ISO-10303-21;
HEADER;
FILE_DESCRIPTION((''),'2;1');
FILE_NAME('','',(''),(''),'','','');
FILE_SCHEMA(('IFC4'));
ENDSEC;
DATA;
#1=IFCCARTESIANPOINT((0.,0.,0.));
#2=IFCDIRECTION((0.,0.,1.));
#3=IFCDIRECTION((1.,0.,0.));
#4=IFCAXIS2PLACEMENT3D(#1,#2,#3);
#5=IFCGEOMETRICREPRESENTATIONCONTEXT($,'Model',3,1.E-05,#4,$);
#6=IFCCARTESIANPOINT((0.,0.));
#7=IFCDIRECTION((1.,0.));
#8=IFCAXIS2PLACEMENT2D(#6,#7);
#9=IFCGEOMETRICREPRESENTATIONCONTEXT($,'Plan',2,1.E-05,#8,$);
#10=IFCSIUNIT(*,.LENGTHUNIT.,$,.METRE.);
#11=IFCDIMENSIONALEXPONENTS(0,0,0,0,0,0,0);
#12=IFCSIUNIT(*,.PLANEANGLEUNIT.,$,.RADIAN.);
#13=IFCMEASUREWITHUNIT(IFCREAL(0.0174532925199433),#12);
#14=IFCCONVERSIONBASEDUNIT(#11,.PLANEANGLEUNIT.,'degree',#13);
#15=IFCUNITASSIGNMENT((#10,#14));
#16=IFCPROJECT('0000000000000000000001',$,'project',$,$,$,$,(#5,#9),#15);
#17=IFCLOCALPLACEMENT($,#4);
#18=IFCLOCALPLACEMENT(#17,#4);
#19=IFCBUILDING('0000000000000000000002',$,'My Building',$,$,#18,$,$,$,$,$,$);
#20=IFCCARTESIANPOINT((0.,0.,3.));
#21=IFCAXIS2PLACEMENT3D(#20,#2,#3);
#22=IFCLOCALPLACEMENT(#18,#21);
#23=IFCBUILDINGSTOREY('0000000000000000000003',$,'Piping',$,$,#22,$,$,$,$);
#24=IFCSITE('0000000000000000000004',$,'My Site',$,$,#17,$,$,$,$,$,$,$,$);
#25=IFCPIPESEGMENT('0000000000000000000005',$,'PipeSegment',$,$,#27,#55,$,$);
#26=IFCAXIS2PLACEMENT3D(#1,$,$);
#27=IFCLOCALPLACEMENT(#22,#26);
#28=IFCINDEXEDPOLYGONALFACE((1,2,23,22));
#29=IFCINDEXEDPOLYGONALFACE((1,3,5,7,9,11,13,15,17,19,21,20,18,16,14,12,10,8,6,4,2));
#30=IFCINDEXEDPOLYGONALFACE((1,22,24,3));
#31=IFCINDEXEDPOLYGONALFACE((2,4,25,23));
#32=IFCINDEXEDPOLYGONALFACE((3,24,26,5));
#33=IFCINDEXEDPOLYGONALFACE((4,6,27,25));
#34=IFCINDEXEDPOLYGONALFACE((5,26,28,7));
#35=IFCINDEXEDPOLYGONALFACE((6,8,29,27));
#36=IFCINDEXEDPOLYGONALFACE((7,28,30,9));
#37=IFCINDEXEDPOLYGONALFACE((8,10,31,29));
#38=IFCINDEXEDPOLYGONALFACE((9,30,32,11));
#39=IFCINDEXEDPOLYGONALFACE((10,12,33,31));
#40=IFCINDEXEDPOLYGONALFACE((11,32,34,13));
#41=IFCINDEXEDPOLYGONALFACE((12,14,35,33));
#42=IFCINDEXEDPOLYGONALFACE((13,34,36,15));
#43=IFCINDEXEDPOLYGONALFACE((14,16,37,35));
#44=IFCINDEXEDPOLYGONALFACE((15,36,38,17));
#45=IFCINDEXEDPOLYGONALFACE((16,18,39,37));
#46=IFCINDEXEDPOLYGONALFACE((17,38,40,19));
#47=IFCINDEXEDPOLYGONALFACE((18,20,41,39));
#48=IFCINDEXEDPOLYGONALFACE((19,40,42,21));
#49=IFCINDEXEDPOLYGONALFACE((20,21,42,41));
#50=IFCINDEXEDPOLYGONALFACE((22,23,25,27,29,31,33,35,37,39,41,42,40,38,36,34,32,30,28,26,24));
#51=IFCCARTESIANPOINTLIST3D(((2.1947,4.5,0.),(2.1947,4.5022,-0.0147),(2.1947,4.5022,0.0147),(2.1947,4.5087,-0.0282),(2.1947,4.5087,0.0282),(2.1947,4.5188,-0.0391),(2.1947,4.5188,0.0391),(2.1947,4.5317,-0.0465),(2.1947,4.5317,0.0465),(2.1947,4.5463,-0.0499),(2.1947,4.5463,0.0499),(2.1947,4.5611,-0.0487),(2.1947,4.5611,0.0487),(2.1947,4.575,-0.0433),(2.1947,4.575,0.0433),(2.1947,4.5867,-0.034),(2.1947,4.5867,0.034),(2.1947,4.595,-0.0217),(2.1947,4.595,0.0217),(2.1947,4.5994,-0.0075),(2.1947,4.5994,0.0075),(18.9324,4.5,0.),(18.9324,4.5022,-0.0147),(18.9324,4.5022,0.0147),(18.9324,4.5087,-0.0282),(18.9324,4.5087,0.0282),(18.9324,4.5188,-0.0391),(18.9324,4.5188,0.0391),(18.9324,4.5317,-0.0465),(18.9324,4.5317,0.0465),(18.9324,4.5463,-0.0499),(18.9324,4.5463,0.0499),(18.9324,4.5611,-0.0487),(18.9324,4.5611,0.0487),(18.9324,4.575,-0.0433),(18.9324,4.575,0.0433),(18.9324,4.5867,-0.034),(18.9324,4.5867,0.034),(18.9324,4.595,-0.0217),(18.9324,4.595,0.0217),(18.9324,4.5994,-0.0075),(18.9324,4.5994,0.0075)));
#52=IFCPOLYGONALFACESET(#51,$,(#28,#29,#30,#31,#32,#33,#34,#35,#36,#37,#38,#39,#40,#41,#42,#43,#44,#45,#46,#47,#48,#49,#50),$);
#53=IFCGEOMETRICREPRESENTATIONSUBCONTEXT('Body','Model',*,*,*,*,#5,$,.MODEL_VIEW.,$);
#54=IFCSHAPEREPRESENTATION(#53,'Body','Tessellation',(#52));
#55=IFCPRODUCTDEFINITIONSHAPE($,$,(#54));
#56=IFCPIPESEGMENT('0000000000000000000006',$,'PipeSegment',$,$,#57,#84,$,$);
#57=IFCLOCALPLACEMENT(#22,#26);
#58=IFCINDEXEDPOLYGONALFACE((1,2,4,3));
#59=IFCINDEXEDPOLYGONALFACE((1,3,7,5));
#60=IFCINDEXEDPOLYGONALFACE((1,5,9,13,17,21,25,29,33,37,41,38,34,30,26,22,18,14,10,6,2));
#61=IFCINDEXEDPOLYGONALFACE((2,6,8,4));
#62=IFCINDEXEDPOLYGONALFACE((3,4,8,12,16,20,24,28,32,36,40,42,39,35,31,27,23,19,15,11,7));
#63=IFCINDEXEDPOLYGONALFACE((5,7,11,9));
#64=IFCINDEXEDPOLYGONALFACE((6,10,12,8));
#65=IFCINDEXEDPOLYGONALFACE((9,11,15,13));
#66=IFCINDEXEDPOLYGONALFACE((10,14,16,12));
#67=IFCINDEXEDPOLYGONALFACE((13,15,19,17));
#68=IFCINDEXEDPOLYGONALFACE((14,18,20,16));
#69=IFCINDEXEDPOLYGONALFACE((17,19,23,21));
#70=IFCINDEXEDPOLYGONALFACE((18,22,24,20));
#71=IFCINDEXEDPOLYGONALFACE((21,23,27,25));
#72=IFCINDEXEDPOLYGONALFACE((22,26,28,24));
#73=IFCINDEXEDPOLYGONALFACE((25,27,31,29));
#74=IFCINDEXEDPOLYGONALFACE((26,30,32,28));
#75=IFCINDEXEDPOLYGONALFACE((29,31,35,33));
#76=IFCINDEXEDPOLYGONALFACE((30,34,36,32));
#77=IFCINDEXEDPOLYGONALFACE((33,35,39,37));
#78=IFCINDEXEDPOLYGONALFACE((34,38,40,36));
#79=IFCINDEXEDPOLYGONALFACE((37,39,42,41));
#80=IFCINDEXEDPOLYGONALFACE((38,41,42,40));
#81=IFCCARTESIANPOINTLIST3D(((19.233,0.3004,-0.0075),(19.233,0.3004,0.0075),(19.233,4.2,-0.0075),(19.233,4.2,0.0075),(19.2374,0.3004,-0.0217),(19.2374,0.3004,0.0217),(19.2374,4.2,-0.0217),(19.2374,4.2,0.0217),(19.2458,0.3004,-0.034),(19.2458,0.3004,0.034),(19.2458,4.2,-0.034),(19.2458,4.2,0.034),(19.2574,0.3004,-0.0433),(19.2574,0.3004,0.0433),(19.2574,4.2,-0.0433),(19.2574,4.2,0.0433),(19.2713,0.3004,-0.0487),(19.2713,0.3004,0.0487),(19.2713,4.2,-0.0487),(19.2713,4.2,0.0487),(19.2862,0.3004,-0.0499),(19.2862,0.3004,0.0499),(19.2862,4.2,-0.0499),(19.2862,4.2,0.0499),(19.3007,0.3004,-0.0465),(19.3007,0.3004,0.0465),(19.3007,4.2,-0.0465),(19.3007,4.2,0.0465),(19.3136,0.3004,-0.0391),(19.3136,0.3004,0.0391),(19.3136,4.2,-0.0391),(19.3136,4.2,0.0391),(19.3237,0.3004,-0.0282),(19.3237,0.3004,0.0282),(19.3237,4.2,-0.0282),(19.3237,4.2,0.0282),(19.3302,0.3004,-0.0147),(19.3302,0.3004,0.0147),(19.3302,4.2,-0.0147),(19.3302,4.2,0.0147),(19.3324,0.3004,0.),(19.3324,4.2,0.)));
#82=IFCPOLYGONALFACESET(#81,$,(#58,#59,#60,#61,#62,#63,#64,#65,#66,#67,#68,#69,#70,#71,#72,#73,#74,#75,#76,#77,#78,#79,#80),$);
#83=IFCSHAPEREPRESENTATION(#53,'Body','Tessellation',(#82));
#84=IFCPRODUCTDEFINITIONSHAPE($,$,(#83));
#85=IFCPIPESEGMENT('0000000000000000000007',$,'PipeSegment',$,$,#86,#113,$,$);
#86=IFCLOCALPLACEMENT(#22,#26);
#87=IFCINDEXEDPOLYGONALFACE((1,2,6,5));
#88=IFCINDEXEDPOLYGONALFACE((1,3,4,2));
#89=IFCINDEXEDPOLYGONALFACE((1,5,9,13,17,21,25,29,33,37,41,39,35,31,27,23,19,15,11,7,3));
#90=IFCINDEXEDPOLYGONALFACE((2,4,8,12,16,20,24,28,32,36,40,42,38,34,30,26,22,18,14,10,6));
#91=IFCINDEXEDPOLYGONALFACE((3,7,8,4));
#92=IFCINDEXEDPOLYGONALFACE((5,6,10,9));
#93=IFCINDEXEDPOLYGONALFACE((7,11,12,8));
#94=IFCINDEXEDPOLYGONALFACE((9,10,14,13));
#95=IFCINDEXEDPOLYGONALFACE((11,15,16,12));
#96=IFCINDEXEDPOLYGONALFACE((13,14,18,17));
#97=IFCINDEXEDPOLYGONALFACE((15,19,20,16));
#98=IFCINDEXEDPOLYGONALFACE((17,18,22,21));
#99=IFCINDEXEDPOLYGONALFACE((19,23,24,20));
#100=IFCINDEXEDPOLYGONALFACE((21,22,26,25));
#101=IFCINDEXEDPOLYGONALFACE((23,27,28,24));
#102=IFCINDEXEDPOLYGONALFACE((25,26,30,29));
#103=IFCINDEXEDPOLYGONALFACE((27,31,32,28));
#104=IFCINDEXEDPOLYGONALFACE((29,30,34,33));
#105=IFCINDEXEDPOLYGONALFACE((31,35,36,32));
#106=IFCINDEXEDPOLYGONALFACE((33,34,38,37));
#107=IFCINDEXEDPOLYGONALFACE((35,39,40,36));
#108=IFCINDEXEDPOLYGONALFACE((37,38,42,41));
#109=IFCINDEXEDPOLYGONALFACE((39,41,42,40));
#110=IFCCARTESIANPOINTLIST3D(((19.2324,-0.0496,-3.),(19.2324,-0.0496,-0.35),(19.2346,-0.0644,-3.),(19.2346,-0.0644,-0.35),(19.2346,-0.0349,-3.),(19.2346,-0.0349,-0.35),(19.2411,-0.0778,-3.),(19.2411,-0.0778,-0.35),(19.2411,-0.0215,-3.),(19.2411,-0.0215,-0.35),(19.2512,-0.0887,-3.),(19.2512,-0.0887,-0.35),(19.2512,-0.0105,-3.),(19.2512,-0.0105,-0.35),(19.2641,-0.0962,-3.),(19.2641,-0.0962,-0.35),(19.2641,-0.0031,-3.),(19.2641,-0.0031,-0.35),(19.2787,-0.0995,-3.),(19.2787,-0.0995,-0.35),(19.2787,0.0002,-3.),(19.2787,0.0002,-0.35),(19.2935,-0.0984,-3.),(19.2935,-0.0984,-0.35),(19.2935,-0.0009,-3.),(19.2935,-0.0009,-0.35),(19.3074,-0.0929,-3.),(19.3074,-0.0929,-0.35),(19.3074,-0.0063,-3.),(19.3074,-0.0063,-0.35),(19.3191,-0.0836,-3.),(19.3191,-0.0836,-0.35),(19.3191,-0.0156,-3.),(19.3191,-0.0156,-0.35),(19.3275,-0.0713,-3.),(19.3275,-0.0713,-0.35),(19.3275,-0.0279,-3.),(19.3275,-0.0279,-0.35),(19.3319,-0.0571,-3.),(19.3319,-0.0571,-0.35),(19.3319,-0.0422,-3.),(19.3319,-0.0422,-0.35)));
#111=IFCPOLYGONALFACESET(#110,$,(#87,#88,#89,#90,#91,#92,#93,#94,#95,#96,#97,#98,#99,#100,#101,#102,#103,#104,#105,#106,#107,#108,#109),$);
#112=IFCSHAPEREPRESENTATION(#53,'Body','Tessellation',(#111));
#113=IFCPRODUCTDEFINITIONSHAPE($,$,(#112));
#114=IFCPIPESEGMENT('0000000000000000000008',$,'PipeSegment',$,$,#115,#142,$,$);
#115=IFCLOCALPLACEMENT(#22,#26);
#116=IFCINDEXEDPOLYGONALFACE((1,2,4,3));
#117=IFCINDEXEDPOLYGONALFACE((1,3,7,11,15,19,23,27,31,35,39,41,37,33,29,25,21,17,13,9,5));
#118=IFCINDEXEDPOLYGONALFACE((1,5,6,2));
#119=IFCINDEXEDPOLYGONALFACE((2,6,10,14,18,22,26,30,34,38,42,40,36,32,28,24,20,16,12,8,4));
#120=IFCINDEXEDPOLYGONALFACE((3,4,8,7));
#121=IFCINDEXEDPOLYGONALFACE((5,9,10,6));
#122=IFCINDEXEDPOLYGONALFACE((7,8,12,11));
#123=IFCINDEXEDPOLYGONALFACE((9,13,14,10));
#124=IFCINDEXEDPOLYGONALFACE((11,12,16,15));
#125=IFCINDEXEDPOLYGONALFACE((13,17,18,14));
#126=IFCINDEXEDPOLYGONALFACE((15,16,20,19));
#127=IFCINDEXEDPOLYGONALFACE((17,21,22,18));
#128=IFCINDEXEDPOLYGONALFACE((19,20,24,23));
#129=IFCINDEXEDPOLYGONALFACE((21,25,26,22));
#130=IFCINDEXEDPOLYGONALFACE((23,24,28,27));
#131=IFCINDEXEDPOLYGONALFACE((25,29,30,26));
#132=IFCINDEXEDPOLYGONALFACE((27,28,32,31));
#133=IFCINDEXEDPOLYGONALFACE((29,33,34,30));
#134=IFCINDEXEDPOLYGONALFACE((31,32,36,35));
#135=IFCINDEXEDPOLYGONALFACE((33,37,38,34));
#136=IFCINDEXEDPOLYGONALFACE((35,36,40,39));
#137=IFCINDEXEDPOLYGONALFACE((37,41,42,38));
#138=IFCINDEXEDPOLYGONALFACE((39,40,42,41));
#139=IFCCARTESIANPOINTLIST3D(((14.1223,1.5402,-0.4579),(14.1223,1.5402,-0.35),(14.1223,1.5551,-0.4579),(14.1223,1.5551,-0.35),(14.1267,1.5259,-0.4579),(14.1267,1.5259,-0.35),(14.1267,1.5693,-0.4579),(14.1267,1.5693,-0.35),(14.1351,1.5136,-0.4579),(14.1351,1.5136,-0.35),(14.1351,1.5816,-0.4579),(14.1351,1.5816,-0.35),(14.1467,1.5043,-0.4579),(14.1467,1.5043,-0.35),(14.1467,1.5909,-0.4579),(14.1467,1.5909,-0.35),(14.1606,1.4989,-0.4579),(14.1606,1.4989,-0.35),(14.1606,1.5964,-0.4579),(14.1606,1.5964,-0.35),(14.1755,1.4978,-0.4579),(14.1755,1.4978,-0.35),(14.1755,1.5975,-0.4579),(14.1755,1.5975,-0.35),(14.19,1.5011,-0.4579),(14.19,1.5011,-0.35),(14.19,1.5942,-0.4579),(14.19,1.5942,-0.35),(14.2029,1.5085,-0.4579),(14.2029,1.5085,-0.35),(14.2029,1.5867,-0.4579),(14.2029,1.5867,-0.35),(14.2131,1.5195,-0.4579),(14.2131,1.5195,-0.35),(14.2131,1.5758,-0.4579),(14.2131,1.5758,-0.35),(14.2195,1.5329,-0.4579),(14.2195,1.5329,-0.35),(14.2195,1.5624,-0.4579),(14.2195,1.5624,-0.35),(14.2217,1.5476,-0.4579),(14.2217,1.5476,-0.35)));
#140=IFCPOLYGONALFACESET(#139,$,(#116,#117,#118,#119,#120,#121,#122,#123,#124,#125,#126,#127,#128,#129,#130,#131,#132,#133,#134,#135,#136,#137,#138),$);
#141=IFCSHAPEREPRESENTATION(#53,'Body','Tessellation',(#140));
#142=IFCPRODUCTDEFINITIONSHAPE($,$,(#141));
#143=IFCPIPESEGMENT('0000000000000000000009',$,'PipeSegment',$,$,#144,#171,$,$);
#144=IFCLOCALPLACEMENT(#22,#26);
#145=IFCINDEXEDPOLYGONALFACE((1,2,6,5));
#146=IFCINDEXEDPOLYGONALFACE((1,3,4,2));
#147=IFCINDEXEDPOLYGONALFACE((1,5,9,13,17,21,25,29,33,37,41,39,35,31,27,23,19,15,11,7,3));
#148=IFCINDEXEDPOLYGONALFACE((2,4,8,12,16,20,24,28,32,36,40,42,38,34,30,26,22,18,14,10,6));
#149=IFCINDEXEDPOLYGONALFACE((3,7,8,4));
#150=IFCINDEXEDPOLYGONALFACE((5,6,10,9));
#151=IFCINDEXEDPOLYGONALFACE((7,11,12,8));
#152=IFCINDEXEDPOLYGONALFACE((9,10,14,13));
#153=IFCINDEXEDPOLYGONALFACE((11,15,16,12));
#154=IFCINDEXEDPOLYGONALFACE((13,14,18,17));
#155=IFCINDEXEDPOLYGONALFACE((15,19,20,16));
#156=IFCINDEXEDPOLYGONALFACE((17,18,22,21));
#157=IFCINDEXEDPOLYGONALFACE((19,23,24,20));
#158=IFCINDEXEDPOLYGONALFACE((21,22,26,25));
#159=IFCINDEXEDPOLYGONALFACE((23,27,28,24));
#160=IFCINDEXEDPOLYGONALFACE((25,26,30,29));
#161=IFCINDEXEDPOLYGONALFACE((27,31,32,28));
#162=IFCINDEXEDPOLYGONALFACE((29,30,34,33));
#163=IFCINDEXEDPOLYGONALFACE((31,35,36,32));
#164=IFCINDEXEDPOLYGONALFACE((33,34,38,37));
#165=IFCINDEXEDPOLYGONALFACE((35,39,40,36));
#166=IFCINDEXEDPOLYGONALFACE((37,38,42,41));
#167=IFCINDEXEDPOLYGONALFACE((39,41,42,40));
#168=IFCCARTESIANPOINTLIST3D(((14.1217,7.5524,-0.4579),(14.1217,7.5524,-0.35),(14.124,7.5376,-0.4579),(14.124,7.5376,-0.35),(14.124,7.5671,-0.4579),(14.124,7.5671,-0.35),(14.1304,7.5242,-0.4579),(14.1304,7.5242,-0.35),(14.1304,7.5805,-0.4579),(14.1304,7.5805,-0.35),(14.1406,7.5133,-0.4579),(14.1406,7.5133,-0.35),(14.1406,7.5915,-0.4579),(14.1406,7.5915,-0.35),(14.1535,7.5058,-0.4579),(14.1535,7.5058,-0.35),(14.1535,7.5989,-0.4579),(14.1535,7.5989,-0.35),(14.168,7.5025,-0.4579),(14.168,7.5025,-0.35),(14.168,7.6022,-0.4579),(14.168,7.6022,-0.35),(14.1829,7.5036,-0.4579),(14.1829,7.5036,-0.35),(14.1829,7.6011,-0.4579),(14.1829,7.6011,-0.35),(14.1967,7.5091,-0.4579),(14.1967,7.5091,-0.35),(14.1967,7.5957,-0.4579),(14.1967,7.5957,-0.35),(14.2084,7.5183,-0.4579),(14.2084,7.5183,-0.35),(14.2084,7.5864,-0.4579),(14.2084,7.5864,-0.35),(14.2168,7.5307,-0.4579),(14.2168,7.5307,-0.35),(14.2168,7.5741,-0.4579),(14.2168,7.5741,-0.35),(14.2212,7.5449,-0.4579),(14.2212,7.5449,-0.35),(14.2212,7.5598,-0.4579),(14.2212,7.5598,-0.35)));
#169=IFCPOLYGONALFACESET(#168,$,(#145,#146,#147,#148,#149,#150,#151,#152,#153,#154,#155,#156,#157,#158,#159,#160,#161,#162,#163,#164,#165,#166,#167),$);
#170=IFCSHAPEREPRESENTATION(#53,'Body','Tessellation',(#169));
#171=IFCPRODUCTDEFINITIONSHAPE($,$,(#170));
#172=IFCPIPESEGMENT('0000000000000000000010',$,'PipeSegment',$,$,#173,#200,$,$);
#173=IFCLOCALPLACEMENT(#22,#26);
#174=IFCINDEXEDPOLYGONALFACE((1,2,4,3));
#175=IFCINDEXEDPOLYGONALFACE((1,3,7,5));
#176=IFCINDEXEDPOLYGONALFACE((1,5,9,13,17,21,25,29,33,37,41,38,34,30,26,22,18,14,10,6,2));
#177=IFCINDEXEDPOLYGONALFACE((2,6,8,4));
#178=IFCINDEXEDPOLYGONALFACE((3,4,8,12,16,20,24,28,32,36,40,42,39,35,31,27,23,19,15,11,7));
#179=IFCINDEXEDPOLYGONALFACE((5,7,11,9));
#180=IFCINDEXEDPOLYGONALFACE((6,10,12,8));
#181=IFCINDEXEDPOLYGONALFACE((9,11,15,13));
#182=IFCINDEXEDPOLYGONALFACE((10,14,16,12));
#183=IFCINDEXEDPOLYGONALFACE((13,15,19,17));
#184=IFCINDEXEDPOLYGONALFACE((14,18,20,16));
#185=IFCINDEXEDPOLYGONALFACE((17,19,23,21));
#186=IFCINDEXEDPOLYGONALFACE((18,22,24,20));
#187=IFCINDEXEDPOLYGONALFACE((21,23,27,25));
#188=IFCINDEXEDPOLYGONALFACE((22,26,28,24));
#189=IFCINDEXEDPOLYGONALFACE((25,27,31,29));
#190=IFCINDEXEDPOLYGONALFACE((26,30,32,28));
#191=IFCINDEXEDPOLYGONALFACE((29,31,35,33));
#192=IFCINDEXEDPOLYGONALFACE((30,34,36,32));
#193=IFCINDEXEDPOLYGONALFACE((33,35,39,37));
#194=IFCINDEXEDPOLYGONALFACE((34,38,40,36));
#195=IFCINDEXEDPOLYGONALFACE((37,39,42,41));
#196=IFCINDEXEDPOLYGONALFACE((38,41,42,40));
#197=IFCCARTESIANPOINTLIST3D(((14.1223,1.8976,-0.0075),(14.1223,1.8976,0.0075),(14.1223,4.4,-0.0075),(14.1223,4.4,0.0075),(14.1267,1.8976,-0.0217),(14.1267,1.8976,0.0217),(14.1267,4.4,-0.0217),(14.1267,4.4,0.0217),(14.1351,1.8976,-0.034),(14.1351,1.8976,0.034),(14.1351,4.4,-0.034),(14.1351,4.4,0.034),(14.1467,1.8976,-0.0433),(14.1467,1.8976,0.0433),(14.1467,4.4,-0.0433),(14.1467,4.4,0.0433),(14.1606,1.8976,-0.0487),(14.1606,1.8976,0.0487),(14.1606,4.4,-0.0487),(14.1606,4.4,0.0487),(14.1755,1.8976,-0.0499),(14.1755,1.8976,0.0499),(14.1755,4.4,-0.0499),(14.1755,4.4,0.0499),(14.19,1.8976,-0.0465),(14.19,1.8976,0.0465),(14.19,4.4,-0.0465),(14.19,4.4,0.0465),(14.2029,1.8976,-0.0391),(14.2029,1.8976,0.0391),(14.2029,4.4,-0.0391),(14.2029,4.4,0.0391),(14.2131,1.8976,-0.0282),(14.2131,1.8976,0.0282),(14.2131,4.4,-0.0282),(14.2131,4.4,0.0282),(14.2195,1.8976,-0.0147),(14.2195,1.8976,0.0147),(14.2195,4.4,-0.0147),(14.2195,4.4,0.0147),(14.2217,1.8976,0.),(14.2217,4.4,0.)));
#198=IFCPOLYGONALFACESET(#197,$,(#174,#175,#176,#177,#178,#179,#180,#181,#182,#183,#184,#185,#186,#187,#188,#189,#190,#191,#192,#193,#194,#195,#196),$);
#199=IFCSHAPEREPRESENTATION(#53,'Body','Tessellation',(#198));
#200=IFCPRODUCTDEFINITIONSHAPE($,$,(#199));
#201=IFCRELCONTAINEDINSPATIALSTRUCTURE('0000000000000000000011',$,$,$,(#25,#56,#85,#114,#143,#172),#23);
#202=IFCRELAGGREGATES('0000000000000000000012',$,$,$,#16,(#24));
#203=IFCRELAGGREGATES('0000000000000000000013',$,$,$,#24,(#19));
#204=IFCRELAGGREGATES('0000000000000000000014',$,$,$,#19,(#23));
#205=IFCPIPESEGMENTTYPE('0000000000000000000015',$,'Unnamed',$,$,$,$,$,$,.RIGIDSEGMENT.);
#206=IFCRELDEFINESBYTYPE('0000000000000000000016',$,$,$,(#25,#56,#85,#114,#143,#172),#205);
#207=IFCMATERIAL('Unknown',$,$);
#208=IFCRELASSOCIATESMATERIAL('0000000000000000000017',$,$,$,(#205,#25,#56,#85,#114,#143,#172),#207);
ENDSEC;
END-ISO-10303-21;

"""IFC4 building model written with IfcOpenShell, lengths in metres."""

from ifc_helpers import new_model, entity, si_unit, converted_unit, frame, origin_with_axes, origin_2d_with_axis, place, context, subcontext, project, spatial, circle, extrude, material, material_profile, profile_set, profile_usage, type_object, element, save


model = new_model("IFC4")

# Units and contexts
model_context = context("Model", 3, precision=1e-05, world=origin_with_axes())
plan_context = context("Plan", 2, precision=1e-05, world=origin_2d_with_axis())
body_context = subcontext(model_context, "Body", "Model", "MODEL_VIEW")
ifc_project = project(units=[si_unit("LENGTHUNIT", "METRE"), converted_unit("PLANEANGLEUNIT", "degree", entity("IfcReal", 0.0174532925199433), si_unit("PLANEANGLEUNIT", "RADIAN"), dimensions=[0, 0, 0, 0, 0, 0, 0])], contexts=[model_context, plan_context])

# Site, building, storey
site_placement = place(None, origin_with_axes())
site = spatial("IfcSite", under=ifc_project, at=site_placement, Name="My Site")
building_placement = place(site_placement, origin_with_axes())
building = spatial("IfcBuilding", under=site, at=building_placement, Name="My Building")
storey_placement = place(building_placement, frame((0.0, 0.0, 3.0), z_axis=(0.0, 0.0, 1.0), x_axis=(1.0, 0.0, 0.0)))
storey = spatial("IfcBuildingStorey", under=building, at=storey_placement, Name="Piping")

# Pipe segments
ifc_material = material(Name="Unknown")
ifc_material_profile_1 = material_profile(ifc_material, circle(Radius=0.05))
ifc_profile_set_1 = profile_set([ifc_material_profile_1])
ifc_profile_usage_1 = profile_usage(ifc_profile_set_1, cardinal=5)
pipe_segment_type = type_object("IfcPipeSegmentType", Name="Unnamed", PredefinedType="RIGIDSEGMENT", material=ifc_profile_set_1)
pipe_segment_1_placement = place(storey_placement, frame((18.9324, 4.55, 0.0), z_axis=(-1.0, 0.0, 0.0), x_axis=(0.0, -1.0, 0.0)))
element("IfcPipeSegment", 1, at=pipe_segment_1_placement, inside=storey, type_object=pipe_segment_type, material=ifc_profile_usage_1, Name="PipeSegment", context=body_context, shape_type="SweptSolid", body=[
    extrude(circle(Radius=0.05), origin_with_axes(), (0.0, 0.0, 1.0), 16.7377),
])
ifc_profile_usage_2 = profile_usage(ifc_profile_set_1, cardinal=5)
pipe_segment_2_placement = place(storey_placement, frame((19.2824, 4.2, 0.0), z_axis=(0.0, -1.0, 0.0), x_axis=(1.0, 0.0, 0.0)))
element("IfcPipeSegment", 2, at=pipe_segment_2_placement, inside=storey, type_object=pipe_segment_type, material=ifc_profile_usage_2, Name="PipeSegment", context=body_context, shape_type="SweptSolid", body=[
    extrude(circle(Radius=0.05), origin_with_axes(), (0.0, 0.0, 1.0), 3.8996),
])
ifc_profile_usage_3 = profile_usage(ifc_profile_set_1, cardinal=5)
pipe_segment_3_placement = place(storey_placement, frame((19.2824, -0.0496, -0.35), z_axis=(0.0, 0.0, -1.0), x_axis=(-1.0, 0.0, 0.0)))
element("IfcPipeSegment", 3, at=pipe_segment_3_placement, inside=storey, type_object=pipe_segment_type, material=ifc_profile_usage_3, Name="PipeSegment", context=body_context, shape_type="SweptSolid", body=[
    extrude(circle(Radius=0.05), origin_with_axes(), (0.0, 0.0, 1.0), 2.65),
])
ifc_profile_usage_4 = profile_usage(ifc_profile_set_1, cardinal=5)
pipe_segment_4_placement = place(storey_placement, frame((14.1717, 1.5476, -0.35), z_axis=(0.0, 0.0, -1.0), x_axis=(1.0, 0.0, 0.0)))
element("IfcPipeSegment", 4, at=pipe_segment_4_placement, inside=storey, type_object=pipe_segment_type, material=ifc_profile_usage_4, Name="PipeSegment", context=body_context, shape_type="SweptSolid", body=[
    extrude(circle(Radius=0.05), origin_with_axes(), (0.0, 0.0, 1.0), 0.1079),
])
ifc_profile_usage_5 = profile_usage(ifc_profile_set_1, cardinal=5)
pipe_segment_5_placement = place(storey_placement, frame((14.1717, 7.5524, -0.35), z_axis=(0.0, 0.0, -1.0), x_axis=(-1.0, 0.0, 0.0)))
element("IfcPipeSegment", 5, at=pipe_segment_5_placement, inside=storey, type_object=pipe_segment_type, material=ifc_profile_usage_5, Name="PipeSegment", context=body_context, shape_type="SweptSolid", body=[
    extrude(circle(Radius=0.05), origin_with_axes(), (0.0, 0.0, 1.0), 0.1079),
])
ifc_profile_usage_6 = profile_usage(ifc_profile_set_1, cardinal=5)
pipe_segment_6_placement = place(storey_placement, frame((14.1717, 4.4, 0.0), z_axis=(0.0, -1.0, 0.0), x_axis=(1.0, 0.0, 0.0)))
element("IfcPipeSegment", 6, at=pipe_segment_6_placement, inside=storey, type_object=pipe_segment_type, material=ifc_profile_usage_6, Name="PipeSegment", context=body_context, shape_type="SweptSolid", body=[
    extrude(circle(Radius=0.05), origin_with_axes(), (0.0, 0.0, 1.0), 2.5024),
])

save(model, "model.ifc")
